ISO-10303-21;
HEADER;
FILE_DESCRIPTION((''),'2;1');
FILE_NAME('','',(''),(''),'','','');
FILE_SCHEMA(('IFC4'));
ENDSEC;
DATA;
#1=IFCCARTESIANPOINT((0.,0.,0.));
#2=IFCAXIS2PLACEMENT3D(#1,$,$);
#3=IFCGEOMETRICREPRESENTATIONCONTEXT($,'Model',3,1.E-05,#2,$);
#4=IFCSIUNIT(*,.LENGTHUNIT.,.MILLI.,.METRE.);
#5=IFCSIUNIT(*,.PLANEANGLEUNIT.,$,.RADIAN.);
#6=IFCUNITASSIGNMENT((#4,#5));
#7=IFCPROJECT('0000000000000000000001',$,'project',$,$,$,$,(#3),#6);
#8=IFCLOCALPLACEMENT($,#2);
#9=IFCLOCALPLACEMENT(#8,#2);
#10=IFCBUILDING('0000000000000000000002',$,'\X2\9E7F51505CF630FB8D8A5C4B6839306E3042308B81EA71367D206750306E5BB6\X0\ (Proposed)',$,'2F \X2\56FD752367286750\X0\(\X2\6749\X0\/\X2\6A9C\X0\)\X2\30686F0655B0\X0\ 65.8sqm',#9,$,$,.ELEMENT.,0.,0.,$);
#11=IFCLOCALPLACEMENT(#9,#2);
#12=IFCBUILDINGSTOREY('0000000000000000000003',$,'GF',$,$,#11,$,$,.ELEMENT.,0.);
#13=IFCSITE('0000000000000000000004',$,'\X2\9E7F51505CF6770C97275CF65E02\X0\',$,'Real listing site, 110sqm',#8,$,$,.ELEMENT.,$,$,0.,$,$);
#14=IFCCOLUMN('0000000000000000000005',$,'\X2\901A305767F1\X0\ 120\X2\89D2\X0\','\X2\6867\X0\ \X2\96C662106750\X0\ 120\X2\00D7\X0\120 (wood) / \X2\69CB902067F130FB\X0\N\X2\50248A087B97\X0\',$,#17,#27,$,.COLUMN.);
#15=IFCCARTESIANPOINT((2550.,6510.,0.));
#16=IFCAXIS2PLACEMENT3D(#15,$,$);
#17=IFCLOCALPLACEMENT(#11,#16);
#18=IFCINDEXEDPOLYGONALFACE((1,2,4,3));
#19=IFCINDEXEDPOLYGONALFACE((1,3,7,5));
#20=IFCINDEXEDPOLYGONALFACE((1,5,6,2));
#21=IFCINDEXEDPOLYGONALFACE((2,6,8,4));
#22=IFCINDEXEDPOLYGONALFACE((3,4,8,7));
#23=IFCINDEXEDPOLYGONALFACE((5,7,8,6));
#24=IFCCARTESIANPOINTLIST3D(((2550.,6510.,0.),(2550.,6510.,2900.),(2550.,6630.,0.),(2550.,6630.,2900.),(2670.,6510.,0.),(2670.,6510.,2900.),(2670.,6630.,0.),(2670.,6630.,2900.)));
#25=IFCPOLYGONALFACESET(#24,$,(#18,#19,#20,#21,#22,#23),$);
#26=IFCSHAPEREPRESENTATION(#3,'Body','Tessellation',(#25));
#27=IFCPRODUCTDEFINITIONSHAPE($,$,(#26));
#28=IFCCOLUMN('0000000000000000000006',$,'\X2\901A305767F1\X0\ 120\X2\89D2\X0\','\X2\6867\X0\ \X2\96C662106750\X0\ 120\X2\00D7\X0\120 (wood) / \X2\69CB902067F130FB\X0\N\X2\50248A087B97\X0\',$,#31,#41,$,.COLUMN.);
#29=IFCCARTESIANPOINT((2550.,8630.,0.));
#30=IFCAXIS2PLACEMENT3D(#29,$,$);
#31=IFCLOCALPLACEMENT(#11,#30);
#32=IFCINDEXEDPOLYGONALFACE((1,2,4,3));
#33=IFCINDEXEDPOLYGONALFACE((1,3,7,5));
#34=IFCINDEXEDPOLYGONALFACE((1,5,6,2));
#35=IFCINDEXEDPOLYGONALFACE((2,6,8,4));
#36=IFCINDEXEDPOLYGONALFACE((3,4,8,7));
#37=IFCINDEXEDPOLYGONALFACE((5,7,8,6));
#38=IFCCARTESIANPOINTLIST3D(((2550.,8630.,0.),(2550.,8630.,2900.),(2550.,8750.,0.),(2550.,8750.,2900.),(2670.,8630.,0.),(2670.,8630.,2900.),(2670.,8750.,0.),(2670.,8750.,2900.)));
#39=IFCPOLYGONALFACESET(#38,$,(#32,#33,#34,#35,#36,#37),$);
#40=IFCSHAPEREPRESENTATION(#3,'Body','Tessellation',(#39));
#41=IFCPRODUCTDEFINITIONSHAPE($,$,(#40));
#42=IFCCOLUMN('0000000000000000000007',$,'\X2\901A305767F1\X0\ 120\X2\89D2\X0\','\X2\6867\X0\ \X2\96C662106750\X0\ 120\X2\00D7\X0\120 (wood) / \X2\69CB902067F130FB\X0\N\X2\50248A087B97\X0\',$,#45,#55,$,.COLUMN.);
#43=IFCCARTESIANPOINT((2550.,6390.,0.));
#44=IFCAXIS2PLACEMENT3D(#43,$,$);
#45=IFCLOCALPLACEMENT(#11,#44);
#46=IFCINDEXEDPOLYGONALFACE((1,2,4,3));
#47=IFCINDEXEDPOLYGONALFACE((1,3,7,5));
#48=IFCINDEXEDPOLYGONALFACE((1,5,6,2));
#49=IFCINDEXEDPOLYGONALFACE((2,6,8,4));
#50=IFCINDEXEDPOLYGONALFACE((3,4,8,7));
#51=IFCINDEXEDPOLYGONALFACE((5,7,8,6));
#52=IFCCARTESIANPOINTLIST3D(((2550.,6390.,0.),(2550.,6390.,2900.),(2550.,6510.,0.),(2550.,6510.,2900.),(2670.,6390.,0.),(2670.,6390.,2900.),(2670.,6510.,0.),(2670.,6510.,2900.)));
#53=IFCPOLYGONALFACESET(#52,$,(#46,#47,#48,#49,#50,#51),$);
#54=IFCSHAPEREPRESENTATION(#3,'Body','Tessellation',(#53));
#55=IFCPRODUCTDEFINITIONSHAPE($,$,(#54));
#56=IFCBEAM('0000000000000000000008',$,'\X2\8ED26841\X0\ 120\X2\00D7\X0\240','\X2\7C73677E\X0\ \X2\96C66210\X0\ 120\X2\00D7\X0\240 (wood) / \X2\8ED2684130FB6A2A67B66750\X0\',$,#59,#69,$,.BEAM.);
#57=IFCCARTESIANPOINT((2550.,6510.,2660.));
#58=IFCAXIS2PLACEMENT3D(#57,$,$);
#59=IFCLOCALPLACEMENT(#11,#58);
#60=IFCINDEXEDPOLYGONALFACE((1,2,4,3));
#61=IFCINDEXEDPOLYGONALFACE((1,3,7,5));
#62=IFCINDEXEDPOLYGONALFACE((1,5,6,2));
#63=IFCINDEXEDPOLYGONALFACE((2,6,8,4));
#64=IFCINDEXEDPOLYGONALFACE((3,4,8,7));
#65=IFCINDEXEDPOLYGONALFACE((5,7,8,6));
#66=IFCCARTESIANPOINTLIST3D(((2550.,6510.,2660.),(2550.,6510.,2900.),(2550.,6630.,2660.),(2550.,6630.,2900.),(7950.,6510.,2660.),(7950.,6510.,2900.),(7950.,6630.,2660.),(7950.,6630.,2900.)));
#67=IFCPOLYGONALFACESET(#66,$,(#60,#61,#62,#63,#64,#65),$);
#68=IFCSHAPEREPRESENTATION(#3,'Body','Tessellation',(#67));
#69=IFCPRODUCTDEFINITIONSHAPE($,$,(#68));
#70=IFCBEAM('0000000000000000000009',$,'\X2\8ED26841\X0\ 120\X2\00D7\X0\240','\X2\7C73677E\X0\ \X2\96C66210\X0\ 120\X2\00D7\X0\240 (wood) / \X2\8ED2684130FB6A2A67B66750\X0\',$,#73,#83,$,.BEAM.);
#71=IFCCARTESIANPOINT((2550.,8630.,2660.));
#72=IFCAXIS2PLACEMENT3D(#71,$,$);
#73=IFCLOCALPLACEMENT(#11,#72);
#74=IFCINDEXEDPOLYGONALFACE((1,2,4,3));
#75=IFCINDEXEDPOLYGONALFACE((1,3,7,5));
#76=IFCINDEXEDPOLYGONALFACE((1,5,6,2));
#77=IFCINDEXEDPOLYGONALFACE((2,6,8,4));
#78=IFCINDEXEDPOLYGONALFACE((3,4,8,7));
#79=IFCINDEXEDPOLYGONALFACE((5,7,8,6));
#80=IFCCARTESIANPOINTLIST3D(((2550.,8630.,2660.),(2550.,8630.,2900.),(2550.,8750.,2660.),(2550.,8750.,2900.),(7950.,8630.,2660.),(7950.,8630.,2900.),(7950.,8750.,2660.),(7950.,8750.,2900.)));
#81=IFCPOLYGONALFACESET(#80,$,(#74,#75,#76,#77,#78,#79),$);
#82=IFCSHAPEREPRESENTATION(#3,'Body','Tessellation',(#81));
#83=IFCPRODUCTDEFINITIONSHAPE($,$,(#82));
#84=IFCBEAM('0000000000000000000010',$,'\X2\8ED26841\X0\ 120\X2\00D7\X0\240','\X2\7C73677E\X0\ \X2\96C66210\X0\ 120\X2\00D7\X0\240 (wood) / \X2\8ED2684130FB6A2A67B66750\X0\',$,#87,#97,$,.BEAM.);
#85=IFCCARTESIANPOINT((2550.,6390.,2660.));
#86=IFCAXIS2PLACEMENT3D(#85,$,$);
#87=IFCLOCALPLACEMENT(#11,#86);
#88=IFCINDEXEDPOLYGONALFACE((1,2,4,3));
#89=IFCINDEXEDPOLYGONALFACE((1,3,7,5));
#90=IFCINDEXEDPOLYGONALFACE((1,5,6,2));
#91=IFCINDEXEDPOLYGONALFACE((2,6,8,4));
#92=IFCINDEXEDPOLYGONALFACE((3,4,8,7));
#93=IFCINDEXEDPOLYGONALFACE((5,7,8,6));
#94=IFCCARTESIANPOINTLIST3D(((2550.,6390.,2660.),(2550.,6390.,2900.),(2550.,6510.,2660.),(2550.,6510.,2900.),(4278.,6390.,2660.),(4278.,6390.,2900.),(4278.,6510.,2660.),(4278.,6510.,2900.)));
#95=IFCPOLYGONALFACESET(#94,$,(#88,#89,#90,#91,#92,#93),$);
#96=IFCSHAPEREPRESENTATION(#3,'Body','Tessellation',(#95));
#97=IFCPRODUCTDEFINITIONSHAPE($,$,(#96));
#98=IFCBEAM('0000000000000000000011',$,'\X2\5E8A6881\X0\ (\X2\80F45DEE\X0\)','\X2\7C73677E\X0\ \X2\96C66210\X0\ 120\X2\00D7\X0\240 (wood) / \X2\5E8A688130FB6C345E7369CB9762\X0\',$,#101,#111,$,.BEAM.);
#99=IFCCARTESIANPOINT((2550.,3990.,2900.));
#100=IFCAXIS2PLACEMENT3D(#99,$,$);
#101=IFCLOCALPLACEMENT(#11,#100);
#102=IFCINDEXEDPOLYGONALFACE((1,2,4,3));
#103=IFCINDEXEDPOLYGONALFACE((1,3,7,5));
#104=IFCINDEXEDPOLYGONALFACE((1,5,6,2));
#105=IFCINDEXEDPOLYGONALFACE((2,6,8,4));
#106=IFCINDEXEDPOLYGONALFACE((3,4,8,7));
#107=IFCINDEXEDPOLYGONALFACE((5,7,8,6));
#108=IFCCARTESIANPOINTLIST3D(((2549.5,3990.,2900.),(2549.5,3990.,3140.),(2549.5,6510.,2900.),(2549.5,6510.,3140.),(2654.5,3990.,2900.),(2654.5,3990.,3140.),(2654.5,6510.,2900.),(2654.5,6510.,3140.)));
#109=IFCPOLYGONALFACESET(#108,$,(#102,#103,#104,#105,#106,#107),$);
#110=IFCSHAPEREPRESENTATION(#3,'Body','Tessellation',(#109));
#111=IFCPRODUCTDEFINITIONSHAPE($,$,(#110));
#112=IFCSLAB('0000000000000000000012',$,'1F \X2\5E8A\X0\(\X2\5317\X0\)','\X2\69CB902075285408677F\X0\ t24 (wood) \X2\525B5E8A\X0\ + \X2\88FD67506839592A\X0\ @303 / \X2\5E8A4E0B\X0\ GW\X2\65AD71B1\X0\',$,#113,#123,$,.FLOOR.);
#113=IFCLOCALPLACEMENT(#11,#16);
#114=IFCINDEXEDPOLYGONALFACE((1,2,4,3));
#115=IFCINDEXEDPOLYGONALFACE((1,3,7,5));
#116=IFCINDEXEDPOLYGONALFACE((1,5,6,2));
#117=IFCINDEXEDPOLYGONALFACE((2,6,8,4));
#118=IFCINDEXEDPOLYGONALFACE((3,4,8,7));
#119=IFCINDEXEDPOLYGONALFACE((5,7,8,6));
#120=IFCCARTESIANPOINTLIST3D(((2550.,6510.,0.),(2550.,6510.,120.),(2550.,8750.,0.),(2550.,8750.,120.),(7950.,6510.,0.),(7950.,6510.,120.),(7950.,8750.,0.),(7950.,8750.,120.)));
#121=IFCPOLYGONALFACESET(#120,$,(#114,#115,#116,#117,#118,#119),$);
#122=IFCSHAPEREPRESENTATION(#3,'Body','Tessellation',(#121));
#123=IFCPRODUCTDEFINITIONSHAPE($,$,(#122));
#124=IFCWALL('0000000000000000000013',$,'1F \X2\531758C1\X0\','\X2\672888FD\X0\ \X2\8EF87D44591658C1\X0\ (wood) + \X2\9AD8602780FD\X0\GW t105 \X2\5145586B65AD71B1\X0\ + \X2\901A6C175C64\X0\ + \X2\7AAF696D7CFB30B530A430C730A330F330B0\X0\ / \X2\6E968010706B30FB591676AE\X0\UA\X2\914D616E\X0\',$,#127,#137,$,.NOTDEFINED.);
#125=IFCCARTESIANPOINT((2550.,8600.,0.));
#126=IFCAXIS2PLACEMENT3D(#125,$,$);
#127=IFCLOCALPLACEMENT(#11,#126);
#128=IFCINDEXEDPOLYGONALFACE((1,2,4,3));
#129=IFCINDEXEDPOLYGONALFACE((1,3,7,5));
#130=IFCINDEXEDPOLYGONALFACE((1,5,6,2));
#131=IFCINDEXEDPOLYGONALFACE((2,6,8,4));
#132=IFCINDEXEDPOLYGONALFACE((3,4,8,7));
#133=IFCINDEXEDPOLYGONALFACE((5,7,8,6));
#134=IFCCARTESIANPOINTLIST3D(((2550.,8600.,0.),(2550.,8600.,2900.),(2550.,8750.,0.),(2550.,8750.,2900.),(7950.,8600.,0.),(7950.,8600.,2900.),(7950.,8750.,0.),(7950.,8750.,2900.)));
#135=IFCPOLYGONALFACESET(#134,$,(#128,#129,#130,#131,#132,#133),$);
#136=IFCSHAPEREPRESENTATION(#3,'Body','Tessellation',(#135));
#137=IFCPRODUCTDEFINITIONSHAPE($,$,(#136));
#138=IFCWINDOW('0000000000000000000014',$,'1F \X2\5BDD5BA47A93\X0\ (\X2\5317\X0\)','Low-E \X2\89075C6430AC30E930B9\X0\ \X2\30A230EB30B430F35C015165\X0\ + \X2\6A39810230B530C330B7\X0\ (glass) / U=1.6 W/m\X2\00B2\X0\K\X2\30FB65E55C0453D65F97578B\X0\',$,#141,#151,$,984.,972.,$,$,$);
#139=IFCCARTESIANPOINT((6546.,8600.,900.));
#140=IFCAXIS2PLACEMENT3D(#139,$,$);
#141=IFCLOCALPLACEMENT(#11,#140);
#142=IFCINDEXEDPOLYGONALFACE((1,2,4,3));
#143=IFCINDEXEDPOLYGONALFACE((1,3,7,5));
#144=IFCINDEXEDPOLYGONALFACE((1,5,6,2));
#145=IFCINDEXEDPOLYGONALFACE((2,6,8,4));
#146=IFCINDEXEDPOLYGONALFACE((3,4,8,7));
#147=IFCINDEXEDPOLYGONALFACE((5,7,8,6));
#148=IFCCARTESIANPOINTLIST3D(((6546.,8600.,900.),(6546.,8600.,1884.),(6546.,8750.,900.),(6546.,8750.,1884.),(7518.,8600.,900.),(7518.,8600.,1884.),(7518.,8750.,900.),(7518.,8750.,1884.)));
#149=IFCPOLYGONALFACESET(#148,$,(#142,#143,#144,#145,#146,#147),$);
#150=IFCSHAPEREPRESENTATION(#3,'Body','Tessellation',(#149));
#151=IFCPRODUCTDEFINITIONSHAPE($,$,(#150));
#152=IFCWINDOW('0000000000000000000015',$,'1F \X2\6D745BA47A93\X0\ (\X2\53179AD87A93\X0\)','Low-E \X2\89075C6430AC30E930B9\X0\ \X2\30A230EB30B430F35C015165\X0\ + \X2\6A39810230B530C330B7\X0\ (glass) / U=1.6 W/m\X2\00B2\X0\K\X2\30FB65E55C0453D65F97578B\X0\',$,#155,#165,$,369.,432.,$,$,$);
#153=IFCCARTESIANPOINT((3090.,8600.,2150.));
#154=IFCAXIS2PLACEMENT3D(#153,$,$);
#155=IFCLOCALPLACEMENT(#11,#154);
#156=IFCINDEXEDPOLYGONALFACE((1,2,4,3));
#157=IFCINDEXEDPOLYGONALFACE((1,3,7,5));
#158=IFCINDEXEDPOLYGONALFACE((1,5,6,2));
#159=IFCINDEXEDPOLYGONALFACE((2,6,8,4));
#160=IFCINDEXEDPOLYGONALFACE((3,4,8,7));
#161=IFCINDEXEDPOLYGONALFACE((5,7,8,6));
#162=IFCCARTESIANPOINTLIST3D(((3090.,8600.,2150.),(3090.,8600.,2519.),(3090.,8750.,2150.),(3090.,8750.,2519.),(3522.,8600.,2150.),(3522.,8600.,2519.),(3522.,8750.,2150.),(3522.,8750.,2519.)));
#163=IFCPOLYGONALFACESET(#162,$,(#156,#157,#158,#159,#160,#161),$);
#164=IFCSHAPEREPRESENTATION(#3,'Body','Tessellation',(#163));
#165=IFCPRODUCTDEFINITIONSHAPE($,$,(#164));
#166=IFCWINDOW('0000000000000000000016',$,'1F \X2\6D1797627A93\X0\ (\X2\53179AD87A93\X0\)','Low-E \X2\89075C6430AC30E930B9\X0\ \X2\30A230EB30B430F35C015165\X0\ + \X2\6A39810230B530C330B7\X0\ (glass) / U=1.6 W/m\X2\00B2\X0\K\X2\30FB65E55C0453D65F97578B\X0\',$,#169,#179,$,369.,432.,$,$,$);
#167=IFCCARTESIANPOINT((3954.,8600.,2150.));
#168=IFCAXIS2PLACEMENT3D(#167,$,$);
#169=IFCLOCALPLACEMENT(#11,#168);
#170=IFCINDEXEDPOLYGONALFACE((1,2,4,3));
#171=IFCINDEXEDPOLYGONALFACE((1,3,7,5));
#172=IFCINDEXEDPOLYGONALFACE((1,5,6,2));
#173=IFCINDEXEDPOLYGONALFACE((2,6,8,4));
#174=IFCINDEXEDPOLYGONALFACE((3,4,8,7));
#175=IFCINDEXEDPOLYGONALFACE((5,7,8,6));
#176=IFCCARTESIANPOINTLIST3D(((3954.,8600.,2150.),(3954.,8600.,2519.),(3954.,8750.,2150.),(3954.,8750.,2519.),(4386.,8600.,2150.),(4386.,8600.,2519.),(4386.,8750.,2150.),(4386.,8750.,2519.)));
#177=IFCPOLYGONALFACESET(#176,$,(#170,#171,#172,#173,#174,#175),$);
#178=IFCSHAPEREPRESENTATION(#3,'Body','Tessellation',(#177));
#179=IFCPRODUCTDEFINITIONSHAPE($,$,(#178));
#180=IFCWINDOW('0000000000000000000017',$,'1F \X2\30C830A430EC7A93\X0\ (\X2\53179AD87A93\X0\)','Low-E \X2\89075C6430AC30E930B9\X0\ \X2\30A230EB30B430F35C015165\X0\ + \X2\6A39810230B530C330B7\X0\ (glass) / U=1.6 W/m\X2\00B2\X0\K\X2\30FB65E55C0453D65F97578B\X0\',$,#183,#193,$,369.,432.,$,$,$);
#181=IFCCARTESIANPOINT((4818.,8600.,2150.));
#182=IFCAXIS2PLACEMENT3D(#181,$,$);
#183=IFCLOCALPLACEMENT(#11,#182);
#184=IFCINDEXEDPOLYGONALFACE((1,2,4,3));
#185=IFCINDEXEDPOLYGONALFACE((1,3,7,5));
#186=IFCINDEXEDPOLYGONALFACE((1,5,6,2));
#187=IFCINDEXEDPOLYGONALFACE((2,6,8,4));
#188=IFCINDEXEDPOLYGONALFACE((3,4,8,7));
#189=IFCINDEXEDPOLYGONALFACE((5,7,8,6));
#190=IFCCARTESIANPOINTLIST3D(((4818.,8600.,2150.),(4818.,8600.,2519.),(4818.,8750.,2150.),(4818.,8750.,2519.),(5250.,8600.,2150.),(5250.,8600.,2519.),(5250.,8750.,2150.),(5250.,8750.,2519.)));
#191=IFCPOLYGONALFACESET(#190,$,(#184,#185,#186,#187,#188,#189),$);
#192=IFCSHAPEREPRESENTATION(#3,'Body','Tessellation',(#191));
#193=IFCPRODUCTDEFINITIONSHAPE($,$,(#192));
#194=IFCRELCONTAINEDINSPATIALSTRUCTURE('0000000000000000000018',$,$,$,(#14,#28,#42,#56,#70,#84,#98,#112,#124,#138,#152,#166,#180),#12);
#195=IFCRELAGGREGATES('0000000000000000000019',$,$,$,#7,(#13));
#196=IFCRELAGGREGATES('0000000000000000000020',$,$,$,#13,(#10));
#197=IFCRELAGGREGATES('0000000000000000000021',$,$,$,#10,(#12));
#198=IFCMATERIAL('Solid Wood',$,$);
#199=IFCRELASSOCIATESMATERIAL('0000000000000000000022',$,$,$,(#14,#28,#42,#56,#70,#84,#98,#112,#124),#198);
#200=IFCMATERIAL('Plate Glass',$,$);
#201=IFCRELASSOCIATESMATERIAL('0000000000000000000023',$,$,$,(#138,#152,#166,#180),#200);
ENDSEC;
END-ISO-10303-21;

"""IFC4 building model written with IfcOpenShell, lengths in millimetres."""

from ifc_helpers import new_model, si_unit, frame, frame_2d, origin, place, context, project, spatial, rectangle, extrude, material, element, fill, save


model = new_model("IFC4")

# Units and contexts
model_context = context("Model", 3, precision=1e-05, world=origin())
ifc_project = project(units=[si_unit("LENGTHUNIT", "METRE", prefix="MILLI"), si_unit("PLANEANGLEUNIT", "RADIAN")], contexts=[model_context])

# Site, building, storey
site_placement = place(None, origin())
site = spatial("IfcSite", under=ifc_project, at=site_placement, Name="鹿児島県霧島市", ObjectType="Real listing site, 110sqm", CompositionType="ELEMENT", RefElevation=0.0)
building_placement = place(site_placement, origin())
building = spatial("IfcBuilding", under=site, at=building_placement, Name="鹿児島・越屋根のある自然素材の家 (Proposed)", ObjectType="2F 国産木材(杉/檜)と漆喰 65.8sqm", CompositionType="ELEMENT", ElevationOfRefHeight=0.0, ElevationOfTerrain=0.0)
storey_placement = place(building_placement, origin())
storey = spatial("IfcBuildingStorey", under=building, at=storey_placement, Name="GF", CompositionType="ELEMENT", Elevation=0.0)

# Columns
ifc_material_1 = material(Name="Solid Wood")
column_1_placement = place(storey_placement, frame((2550.0, 6510.0, 0.0)))
element("IfcColumn", 1, at=column_1_placement, inside=storey, material=ifc_material_1, Name="通し柱 120角", Description="桧 集成材 120×120 (wood) / 構造柱・N値計算", PredefinedType="COLUMN", context=model_context, shape_type="SweptSolid", body=[
    extrude(rectangle(XDim=120.0, YDim=120.0, at=frame_2d((60.0, 60.0))), frame((2550.0, 6510.0, 0.0)), (0.0, 0.0, 1.0), 2900.0),
])
column_2_placement = place(storey_placement, frame((2550.0, 8630.0, 0.0)))
element("IfcColumn", 2, at=column_2_placement, inside=storey, material=ifc_material_1, Name="通し柱 120角", Description="桧 集成材 120×120 (wood) / 構造柱・N値計算", PredefinedType="COLUMN", context=model_context, shape_type="SweptSolid", body=[
    extrude(rectangle(XDim=120.0, YDim=120.0, at=frame_2d((60.0, 60.0))), frame((2550.0, 8630.0, 0.0)), (0.0, 0.0, 1.0), 2900.0),
])
column_3_placement = place(storey_placement, frame((2550.0, 6390.0, 0.0)))
element("IfcColumn", 3, at=column_3_placement, inside=storey, material=ifc_material_1, Name="通し柱 120角", Description="桧 集成材 120×120 (wood) / 構造柱・N値計算", PredefinedType="COLUMN", context=model_context, shape_type="SweptSolid", body=[
    extrude(rectangle(XDim=120.0, YDim=120.0, at=frame_2d((60.0, 60.0))), frame((2550.0, 6390.0, 0.0)), (0.0, 0.0, 1.0), 2900.0),
])

# Beams
beam_1_placement = place(storey_placement, frame((2550.0, 6510.0, 2660.0)))
element("IfcBeam", 4, at=beam_1_placement, inside=storey, material=ifc_material_1, Name="軒桁 120×240", Description="米松 集成 120×240 (wood) / 軒桁・横架材", PredefinedType="BEAM", context=model_context, shape_type="SweptSolid", body=[
    extrude(rectangle(XDim=5400.0, YDim=120.0, at=frame_2d((2700.0, 60.0))), frame((2550.0, 6510.0, 2660.0)), (0.0, 0.0, 1.0), 240.0),
])
beam_2_placement = place(storey_placement, frame((2550.0, 8630.0, 2660.0)))
element("IfcBeam", 5, at=beam_2_placement, inside=storey, material=ifc_material_1, Name="軒桁 120×240", Description="米松 集成 120×240 (wood) / 軒桁・横架材", PredefinedType="BEAM", context=model_context, shape_type="SweptSolid", body=[
    extrude(rectangle(XDim=5400.0, YDim=120.0, at=frame_2d((2700.0, 60.0))), frame((2550.0, 8630.0, 2660.0)), (0.0, 0.0, 1.0), 240.0),
])
beam_3_placement = place(storey_placement, frame((2550.0, 6390.0, 2660.0)))
element("IfcBeam", 6, at=beam_3_placement, inside=storey, material=ifc_material_1, Name="軒桁 120×240", Description="米松 集成 120×240 (wood) / 軒桁・横架材", PredefinedType="BEAM", context=model_context, shape_type="SweptSolid", body=[
    extrude(rectangle(XDim=1728.0, YDim=120.0, at=frame_2d((864.0, 60.0))), frame((2550.0, 6390.0, 2660.0)), (0.0, 0.0, 1.0), 240.0),
])
beam_4_placement = place(storey_placement, frame((2550.0, 3990.0, 2900.0)))
element("IfcBeam", 7, at=beam_4_placement, inside=storey, material=ifc_material_1, Name="床梁 (胴差)", Description="米松 集成 120×240 (wood) / 床梁・水平構面", PredefinedType="BEAM", context=model_context, shape_type="SweptSolid", body=[
    extrude(rectangle(XDim=105.0, YDim=2520.0, at=frame_2d((52.0, 1260.0))), frame((2550.0, 3990.0, 2900.0)), (0.0, 0.0, 1.0), 240.0),
])

# Slab
slab_placement = place(storey_placement, frame((2550.0, 6510.0, 0.0)))
element("IfcSlab", 8, at=slab_placement, inside=storey, material=ifc_material_1, Name="1F 床(北)", Description="構造用合板 t24 (wood) 剛床 + 製材根太 @303 / 床下 GW断熱", PredefinedType="FLOOR", context=model_context, shape_type="SweptSolid", body=[
    extrude(rectangle(XDim=5400.0, YDim=2240.0, at=frame_2d((2700.0, 1120.0))), frame((2550.0, 6510.0, 0.0)), (0.0, 0.0, 1.0), 120.0),
])

# Wall, openings, windows
wall_1_placement = place(storey_placement, frame((2550.0, 8600.0, 0.0)))
wall_1 = element("IfcWall", 9, at=wall_1_placement, inside=storey, material=ifc_material_1, Name="1F 北壁", Description="木製 軸組外壁 (wood) + 高性能GW t105 充填断熱 + 通気層 + 窯業系サイディング / 準耐火・外皮UA配慮", PredefinedType="NOTDEFINED", context=model_context, shape_type="SweptSolid", body=[
    extrude(rectangle(XDim=5400.0, YDim=150.0, at=frame_2d((2700.0, 75.0))), frame((2550.0, 8600.0, 0.0)), (0.0, 0.0, 1.0), 2900.0),
])
opening_1_placement = place(storey_placement, frame((6546.0, 8600.0, 900.0)))
opening_1 = element("IfcOpeningElement", 10, at=opening_1_placement, cuts=wall_1, PredefinedType="NOTDEFINED", context=model_context, shape_type="SweptSolid", body=[
    extrude(rectangle(XDim=972.0, YDim=150.0, at=frame_2d((486.0, 75.0))), frame((6546.0, 8600.0, 900.0)), (0.0, 0.0, 1.0), 984.0),
])
opening_2_placement = place(storey_placement, frame((3090.0, 8600.0, 2150.0)))
opening_2 = element("IfcOpeningElement", 11, at=opening_2_placement, cuts=wall_1, PredefinedType="NOTDEFINED", context=model_context, shape_type="SweptSolid", body=[
    extrude(rectangle(XDim=432.0, YDim=150.0, at=frame_2d((216.0, 75.0))), frame((3090.0, 8600.0, 2150.0)), (0.0, 0.0, 1.0), 369.0),
])
opening_3_placement = place(storey_placement, frame((3954.0, 8600.0, 2150.0)))
opening_3 = element("IfcOpeningElement", 12, at=opening_3_placement, cuts=wall_1, PredefinedType="NOTDEFINED", context=model_context, shape_type="SweptSolid", body=[
    extrude(rectangle(XDim=432.0, YDim=150.0, at=frame_2d((216.0, 75.0))), frame((3954.0, 8600.0, 2150.0)), (0.0, 0.0, 1.0), 369.0),
])
opening_4_placement = place(storey_placement, frame((4818.0, 8600.0, 2150.0)))
opening_4 = element("IfcOpeningElement", 13, at=opening_4_placement, cuts=wall_1, PredefinedType="NOTDEFINED", context=model_context, shape_type="SweptSolid", body=[
    extrude(rectangle(XDim=432.0, YDim=150.0, at=frame_2d((216.0, 75.0))), frame((4818.0, 8600.0, 2150.0)), (0.0, 0.0, 1.0), 369.0),
])
ifc_material_2 = material(Name="Plate Glass")
window_1_placement = place(storey_placement, frame((6546.0, 8600.0, 900.0)))
window_1 = element("IfcWindow", 14, at=window_1_placement, inside=storey, material=ifc_material_2, Name="1F 寝室窓 (北)", Description="Low-E 複層ガラス アルゴン封入 + 樹脂サッシ (glass) / U=1.6 W/m²K・日射取得型", OverallHeight=984.0, OverallWidth=972.0, context=model_context, shape_type="SweptSolid", body=[
    extrude(rectangle(XDim=972.0, YDim=150.0, at=frame_2d((486.0, 75.0))), frame((6546.0, 8600.0, 900.0)), (0.0, 0.0, 1.0), 984.0),
])
fill(opening_1, window_1)
window_2_placement = place(storey_placement, frame((3090.0, 8600.0, 2150.0)))
window_2 = element("IfcWindow", 15, at=window_2_placement, inside=storey, material=ifc_material_2, Name="1F 浴室窓 (北高窓)", Description="Low-E 複層ガラス アルゴン封入 + 樹脂サッシ (glass) / U=1.6 W/m²K・日射取得型", OverallHeight=369.0, OverallWidth=432.0, context=model_context, shape_type="SweptSolid", body=[
    extrude(rectangle(XDim=432.0, YDim=150.0, at=frame_2d((216.0, 75.0))), frame((3090.0, 8600.0, 2150.0)), (0.0, 0.0, 1.0), 369.0),
])
fill(opening_2, window_2)
window_3_placement = place(storey_placement, frame((3954.0, 8600.0, 2150.0)))
window_3 = element("IfcWindow", 16, at=window_3_placement, inside=storey, material=ifc_material_2, Name="1F 洗面窓 (北高窓)", Description="Low-E 複層ガラス アルゴン封入 + 樹脂サッシ (glass) / U=1.6 W/m²K・日射取得型", OverallHeight=369.0, OverallWidth=432.0, context=model_context, shape_type="SweptSolid", body=[
    extrude(rectangle(XDim=432.0, YDim=150.0, at=frame_2d((216.0, 75.0))), frame((3954.0, 8600.0, 2150.0)), (0.0, 0.0, 1.0), 369.0),
])
fill(opening_3, window_3)
window_4_placement = place(storey_placement, frame((4818.0, 8600.0, 2150.0)))
window_4 = element("IfcWindow", 17, at=window_4_placement, inside=storey, material=ifc_material_2, Name="1F トイレ窓 (北高窓)", Description="Low-E 複層ガラス アルゴン封入 + 樹脂サッシ (glass) / U=1.6 W/m²K・日射取得型", OverallHeight=369.0, OverallWidth=432.0, context=model_context, shape_type="SweptSolid", body=[
    extrude(rectangle(XDim=432.0, YDim=150.0, at=frame_2d((216.0, 75.0))), frame((4818.0, 8600.0, 2150.0)), (0.0, 0.0, 1.0), 369.0),
])
fill(opening_4, window_4)

save(model, "model.ifc")
